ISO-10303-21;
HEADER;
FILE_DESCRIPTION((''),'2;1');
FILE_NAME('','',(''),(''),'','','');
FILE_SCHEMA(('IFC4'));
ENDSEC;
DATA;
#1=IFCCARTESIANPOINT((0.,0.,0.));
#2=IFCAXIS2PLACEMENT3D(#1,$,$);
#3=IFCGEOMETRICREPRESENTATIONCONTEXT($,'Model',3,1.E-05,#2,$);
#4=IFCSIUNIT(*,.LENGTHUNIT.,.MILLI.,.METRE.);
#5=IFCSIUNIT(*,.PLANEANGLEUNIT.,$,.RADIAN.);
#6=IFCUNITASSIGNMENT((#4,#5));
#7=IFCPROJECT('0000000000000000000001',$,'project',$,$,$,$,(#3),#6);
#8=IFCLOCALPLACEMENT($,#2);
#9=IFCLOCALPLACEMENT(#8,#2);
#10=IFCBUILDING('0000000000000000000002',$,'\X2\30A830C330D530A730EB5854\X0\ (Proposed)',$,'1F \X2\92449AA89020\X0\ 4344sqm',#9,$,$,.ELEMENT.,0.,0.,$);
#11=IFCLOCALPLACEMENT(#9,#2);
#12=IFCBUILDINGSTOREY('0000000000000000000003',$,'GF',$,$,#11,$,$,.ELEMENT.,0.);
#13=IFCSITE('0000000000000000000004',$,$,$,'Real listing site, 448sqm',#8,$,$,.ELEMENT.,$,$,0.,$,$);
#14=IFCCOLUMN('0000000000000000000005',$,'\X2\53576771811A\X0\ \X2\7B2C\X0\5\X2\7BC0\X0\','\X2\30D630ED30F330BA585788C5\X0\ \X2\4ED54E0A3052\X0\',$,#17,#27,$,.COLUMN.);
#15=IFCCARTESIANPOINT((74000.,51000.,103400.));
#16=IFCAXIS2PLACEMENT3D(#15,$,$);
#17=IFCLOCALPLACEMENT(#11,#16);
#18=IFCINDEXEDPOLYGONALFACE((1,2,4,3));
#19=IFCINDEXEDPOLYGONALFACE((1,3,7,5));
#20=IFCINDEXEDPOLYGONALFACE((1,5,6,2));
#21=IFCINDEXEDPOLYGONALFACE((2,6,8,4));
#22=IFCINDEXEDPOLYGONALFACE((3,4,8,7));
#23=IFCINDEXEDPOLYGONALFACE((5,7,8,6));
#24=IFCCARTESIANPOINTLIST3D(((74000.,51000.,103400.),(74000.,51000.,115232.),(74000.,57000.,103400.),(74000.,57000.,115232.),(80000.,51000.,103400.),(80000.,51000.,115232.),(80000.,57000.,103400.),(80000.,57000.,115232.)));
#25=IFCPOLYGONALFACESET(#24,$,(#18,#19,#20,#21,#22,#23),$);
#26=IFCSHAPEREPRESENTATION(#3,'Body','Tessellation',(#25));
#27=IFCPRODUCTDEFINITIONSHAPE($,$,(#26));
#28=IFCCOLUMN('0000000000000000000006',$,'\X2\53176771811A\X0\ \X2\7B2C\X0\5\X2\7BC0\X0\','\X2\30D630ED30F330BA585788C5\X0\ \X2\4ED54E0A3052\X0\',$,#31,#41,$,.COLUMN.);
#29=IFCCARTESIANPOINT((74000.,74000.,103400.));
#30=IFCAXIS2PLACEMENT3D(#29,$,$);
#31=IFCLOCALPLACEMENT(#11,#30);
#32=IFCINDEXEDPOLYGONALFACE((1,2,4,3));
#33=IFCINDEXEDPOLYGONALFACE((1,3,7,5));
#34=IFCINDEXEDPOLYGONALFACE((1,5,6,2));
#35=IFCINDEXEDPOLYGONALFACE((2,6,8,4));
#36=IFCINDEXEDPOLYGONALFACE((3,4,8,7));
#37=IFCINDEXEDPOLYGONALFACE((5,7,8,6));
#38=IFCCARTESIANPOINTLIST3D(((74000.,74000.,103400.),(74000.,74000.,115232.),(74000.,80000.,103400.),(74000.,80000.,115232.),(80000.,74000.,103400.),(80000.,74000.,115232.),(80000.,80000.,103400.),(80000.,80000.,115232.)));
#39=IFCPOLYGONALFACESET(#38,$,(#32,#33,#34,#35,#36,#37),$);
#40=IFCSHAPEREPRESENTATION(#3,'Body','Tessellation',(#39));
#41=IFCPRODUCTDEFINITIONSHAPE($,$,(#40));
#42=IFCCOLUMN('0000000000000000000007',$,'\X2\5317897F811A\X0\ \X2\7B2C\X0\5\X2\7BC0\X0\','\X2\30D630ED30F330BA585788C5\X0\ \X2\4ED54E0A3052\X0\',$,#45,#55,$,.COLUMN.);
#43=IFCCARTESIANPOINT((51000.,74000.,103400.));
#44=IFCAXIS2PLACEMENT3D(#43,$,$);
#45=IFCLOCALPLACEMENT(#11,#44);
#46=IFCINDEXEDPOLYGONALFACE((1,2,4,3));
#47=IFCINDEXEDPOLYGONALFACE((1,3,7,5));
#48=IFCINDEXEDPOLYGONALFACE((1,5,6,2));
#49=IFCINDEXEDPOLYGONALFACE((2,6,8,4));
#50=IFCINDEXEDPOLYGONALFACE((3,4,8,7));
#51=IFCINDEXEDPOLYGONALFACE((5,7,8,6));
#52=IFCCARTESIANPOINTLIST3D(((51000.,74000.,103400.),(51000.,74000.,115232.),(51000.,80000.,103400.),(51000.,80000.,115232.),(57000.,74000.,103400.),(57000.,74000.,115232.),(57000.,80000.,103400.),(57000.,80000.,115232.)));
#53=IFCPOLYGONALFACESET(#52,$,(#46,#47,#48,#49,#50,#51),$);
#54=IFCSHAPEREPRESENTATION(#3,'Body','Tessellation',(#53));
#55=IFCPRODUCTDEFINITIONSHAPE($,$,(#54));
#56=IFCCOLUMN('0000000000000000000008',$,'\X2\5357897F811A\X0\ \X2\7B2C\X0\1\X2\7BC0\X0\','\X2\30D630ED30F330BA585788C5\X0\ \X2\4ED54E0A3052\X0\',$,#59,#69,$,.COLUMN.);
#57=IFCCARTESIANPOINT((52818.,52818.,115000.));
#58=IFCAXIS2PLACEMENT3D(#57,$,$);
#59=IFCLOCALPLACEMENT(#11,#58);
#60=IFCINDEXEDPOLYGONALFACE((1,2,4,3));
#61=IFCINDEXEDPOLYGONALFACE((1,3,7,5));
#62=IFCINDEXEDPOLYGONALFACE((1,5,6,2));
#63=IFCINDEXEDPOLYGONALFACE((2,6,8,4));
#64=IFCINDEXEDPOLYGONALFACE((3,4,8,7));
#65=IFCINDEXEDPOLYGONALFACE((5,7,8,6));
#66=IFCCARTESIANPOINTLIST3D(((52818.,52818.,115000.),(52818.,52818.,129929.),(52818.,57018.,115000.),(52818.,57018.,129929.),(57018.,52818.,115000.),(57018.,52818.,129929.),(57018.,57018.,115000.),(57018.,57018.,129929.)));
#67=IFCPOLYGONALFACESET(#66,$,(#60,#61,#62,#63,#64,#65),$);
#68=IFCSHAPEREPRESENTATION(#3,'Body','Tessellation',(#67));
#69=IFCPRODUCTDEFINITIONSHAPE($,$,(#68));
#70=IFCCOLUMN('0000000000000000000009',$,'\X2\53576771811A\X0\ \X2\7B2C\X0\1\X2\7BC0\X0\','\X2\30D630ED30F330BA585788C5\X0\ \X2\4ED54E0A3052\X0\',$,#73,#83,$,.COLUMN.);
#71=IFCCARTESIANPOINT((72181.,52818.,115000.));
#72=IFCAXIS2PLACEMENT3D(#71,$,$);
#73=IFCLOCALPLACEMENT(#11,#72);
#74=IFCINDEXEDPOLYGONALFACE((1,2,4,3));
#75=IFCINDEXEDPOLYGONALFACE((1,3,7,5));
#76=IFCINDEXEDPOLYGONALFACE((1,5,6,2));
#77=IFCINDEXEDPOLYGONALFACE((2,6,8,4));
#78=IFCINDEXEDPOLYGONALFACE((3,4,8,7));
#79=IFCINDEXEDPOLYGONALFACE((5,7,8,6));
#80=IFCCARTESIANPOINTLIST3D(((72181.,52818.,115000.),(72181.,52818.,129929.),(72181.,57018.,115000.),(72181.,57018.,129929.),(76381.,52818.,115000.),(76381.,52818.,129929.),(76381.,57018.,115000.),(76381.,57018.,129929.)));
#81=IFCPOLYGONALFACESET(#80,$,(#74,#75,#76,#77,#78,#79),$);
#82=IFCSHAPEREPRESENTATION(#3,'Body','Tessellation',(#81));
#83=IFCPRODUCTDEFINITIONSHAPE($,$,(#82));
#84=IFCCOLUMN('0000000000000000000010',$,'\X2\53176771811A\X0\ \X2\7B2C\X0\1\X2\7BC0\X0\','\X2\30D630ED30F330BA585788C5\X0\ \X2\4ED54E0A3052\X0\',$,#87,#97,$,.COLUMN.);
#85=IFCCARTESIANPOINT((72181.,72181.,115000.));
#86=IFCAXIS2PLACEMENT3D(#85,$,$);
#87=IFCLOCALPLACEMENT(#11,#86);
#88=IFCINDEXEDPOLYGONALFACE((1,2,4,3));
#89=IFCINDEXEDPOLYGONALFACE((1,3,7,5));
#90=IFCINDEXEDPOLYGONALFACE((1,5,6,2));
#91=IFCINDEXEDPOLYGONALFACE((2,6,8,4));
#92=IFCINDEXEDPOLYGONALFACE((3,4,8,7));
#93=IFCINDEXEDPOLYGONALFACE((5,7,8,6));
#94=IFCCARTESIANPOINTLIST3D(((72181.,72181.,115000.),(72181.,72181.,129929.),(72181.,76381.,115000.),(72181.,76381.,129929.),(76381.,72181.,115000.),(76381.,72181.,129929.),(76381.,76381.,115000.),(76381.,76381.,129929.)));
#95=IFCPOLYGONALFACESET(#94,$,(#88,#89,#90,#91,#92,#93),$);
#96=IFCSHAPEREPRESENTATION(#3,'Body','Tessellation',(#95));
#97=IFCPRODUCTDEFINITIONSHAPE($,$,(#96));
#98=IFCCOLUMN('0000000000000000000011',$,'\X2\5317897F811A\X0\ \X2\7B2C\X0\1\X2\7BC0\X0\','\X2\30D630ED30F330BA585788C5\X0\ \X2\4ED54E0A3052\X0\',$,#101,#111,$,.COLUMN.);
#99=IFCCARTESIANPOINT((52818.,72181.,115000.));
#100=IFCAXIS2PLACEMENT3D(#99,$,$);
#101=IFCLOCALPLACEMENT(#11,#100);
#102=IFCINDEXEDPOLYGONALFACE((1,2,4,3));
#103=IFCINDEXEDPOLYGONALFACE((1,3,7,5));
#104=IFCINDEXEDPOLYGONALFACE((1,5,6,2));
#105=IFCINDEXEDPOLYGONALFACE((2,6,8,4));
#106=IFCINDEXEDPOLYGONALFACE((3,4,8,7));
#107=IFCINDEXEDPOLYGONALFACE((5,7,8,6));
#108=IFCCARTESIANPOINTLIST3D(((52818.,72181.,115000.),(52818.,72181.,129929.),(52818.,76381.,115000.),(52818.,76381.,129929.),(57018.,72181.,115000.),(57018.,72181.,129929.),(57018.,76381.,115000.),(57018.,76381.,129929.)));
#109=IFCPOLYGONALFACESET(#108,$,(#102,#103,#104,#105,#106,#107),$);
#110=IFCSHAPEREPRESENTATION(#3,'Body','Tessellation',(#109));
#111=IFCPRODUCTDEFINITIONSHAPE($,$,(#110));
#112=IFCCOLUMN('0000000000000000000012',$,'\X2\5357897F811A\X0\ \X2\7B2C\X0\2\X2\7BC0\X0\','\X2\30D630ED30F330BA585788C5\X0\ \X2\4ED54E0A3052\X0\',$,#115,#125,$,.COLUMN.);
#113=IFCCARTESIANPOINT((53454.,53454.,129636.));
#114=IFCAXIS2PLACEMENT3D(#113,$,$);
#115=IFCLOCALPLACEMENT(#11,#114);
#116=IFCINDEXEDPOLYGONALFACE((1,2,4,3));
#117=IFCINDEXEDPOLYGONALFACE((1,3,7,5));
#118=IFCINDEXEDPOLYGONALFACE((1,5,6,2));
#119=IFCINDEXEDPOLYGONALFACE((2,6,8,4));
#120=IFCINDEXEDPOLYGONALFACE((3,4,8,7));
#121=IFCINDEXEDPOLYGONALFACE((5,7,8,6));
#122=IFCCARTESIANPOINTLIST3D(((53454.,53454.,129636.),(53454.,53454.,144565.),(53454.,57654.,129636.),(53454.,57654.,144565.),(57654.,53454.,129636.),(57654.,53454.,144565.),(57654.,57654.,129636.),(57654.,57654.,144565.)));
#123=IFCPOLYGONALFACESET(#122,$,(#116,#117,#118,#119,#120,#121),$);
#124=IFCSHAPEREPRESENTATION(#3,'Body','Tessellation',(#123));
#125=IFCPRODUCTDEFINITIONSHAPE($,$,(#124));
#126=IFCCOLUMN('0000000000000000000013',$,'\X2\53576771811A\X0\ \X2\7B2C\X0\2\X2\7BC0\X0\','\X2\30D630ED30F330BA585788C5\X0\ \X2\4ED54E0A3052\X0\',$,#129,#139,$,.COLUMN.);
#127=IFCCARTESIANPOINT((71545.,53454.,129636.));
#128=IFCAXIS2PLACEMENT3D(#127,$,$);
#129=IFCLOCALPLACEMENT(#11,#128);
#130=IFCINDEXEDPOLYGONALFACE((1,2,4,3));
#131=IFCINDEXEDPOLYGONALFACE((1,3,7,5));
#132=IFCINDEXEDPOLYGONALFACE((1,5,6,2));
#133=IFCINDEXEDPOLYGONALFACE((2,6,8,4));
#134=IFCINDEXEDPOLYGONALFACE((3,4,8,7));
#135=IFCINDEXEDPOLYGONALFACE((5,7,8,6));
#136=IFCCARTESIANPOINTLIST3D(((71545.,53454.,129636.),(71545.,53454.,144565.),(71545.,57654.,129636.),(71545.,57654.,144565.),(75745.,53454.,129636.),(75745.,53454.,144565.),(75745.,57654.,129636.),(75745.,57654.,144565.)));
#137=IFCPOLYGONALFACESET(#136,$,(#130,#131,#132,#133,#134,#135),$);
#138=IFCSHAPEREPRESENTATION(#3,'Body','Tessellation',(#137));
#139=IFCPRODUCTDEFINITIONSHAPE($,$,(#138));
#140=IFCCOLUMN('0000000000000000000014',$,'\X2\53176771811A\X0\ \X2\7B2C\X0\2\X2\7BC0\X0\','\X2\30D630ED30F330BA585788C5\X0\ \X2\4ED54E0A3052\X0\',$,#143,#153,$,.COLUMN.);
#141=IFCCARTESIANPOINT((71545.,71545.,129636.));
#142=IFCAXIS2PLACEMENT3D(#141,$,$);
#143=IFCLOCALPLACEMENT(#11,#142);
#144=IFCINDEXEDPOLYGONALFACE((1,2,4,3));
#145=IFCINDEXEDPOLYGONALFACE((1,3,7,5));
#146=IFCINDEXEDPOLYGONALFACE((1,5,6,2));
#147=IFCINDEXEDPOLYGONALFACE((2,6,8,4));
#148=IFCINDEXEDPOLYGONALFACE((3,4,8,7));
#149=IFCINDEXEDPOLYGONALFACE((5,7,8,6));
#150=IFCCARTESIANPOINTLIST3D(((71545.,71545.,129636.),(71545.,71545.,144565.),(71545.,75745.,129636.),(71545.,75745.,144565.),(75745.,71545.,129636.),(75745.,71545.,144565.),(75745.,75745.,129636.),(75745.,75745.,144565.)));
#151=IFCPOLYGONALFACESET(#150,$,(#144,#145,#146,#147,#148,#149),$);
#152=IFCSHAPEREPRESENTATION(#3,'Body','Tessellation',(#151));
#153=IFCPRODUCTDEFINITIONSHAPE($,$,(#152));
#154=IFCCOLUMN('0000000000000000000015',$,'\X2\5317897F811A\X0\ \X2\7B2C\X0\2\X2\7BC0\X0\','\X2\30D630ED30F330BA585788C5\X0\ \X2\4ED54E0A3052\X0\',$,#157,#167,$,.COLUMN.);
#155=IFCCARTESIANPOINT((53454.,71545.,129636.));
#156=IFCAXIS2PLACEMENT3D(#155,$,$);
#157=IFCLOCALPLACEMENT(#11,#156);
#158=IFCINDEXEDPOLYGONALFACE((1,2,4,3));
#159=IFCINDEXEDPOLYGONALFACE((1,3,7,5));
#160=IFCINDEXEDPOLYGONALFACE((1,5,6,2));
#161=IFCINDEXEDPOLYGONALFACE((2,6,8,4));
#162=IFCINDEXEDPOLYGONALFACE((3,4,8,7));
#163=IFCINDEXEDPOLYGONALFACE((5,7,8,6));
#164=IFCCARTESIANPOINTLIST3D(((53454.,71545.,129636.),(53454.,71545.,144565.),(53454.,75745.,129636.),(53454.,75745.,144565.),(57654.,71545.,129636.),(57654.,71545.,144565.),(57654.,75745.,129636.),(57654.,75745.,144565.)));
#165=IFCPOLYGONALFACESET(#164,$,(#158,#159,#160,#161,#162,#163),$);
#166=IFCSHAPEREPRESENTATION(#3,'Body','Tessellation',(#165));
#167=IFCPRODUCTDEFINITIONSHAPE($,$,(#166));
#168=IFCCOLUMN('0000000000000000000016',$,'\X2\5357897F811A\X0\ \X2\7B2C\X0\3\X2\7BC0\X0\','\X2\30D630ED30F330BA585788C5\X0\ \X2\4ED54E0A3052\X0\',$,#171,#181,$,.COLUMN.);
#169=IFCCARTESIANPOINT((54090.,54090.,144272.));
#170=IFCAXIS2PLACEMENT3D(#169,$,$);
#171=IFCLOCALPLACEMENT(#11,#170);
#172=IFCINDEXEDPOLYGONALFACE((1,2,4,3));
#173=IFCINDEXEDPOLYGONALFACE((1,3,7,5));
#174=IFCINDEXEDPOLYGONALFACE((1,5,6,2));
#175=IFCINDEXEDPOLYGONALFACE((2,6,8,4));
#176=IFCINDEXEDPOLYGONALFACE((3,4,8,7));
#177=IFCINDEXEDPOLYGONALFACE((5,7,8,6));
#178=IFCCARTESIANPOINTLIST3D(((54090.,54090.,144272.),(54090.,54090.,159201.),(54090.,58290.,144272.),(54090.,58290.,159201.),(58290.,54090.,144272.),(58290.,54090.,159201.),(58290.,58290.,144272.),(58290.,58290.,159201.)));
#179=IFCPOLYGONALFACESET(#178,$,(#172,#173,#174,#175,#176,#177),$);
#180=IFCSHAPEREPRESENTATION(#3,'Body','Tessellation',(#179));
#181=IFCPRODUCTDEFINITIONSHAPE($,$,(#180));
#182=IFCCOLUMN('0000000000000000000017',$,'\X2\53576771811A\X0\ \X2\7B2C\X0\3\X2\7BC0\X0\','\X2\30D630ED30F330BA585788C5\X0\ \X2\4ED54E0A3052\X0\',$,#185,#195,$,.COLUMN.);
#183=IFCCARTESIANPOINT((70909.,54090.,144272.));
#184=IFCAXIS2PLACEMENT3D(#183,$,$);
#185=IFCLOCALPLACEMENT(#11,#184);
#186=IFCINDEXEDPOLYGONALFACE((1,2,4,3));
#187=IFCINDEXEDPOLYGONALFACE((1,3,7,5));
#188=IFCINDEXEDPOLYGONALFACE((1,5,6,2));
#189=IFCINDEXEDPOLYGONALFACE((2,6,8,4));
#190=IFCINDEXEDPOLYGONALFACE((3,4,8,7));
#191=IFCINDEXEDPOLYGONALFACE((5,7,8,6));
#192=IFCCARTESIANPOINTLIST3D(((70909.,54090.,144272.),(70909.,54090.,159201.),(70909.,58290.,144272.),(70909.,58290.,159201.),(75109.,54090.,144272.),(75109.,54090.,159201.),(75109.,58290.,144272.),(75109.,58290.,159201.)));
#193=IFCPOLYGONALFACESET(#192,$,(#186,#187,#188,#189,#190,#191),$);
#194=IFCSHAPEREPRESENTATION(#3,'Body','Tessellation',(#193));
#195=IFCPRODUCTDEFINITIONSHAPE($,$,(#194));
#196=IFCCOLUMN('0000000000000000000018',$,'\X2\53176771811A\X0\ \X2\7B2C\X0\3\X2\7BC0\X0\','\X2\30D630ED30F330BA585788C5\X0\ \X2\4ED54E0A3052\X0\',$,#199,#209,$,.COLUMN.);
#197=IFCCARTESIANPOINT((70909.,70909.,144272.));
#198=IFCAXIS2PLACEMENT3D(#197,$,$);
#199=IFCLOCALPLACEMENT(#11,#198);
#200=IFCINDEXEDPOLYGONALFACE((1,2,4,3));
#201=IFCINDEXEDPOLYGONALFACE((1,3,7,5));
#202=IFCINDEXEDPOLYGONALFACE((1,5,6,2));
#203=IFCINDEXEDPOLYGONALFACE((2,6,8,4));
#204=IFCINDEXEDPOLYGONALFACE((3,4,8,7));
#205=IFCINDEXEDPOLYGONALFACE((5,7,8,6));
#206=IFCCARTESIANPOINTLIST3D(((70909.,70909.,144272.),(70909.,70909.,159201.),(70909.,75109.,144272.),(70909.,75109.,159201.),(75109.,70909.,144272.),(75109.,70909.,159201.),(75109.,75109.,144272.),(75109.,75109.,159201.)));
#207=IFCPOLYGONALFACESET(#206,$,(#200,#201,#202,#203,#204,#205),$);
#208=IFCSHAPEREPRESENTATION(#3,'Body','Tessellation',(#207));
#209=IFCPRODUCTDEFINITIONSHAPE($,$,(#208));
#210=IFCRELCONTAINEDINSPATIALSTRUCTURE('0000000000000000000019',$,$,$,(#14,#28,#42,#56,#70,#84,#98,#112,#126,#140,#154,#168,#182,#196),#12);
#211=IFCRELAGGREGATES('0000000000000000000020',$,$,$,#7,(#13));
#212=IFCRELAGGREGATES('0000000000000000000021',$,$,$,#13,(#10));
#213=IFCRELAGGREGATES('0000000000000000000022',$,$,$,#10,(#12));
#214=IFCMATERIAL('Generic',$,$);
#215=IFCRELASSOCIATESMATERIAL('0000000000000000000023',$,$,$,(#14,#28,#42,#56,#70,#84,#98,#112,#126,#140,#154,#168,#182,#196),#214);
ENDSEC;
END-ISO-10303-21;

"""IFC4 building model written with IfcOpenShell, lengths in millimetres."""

from ifc_helpers import new_model, si_unit, frame, frame_2d, origin, place, context, project, spatial, rectangle, extrude, material, element, save


model = new_model("IFC4")

# Units and contexts
model_context = context("Model", 3, precision=1e-05, world=origin())
ifc_project = project(units=[si_unit("LENGTHUNIT", "METRE", prefix="MILLI"), si_unit("PLANEANGLEUNIT", "RADIAN")], contexts=[model_context])

# Site, building, storey
site_placement = place(None, origin())
site = spatial("IfcSite", under=ifc_project, at=site_placement, ObjectType="Real listing site, 448sqm", CompositionType="ELEMENT", RefElevation=0.0)
building_placement = place(site_placement, origin())
building = spatial("IfcBuilding", under=site, at=building_placement, Name="エッフェル塔 (Proposed)", ObjectType="1F 鉄骨造 4344sqm", CompositionType="ELEMENT", ElevationOfRefHeight=0.0, ElevationOfTerrain=0.0)
storey_placement = place(building_placement, origin())
storey = spatial("IfcBuildingStorey", under=building, at=storey_placement, Name="GF", CompositionType="ELEMENT", Elevation=0.0)

# Columns
ifc_material = material(Name="Generic")
column_1_placement = place(storey_placement, frame((74000.0, 51000.0, 103400.0)))
element("IfcColumn", 1, at=column_1_placement, inside=storey, material=ifc_material, Name="南東脚 第5節", Description="ブロンズ塗装 仕上げ", PredefinedType="COLUMN", context=model_context, shape_type="SweptSolid", body=[
    extrude(rectangle(XDim=6000.0, YDim=6000.0, at=frame_2d((3000.0, 3000.0))), frame((74000.0, 51000.0, 103400.0)), (0.0, 0.0, 1.0), 11832.0),
])
column_2_placement = place(storey_placement, frame((74000.0, 74000.0, 103400.0)))
element("IfcColumn", 2, at=column_2_placement, inside=storey, material=ifc_material, Name="北東脚 第5節", Description="ブロンズ塗装 仕上げ", PredefinedType="COLUMN", context=model_context, shape_type="SweptSolid", body=[
    extrude(rectangle(XDim=6000.0, YDim=6000.0, at=frame_2d((3000.0, 3000.0))), frame((74000.0, 74000.0, 103400.0)), (0.0, 0.0, 1.0), 11832.0),
])
column_3_placement = place(storey_placement, frame((51000.0, 74000.0, 103400.0)))
element("IfcColumn", 3, at=column_3_placement, inside=storey, material=ifc_material, Name="北西脚 第5節", Description="ブロンズ塗装 仕上げ", PredefinedType="COLUMN", context=model_context, shape_type="SweptSolid", body=[
    extrude(rectangle(XDim=6000.0, YDim=6000.0, at=frame_2d((3000.0, 3000.0))), frame((51000.0, 74000.0, 103400.0)), (0.0, 0.0, 1.0), 11832.0),
])
column_4_placement = place(storey_placement, frame((52818.0, 52818.0, 115000.0)))
element("IfcColumn", 4, at=column_4_placement, inside=storey, material=ifc_material, Name="南西脚 第1節", Description="ブロンズ塗装 仕上げ", PredefinedType="COLUMN", context=model_context, shape_type="SweptSolid", body=[
    extrude(rectangle(XDim=4200.0, YDim=4200.0, at=frame_2d((2100.0, 2100.0))), frame((52818.0, 52818.0, 115000.0)), (0.0, 0.0, 1.0), 14929.0),
])
column_5_placement = place(storey_placement, frame((72181.0, 52818.0, 115000.0)))
element("IfcColumn", 5, at=column_5_placement, inside=storey, material=ifc_material, Name="南東脚 第1節", Description="ブロンズ塗装 仕上げ", PredefinedType="COLUMN", context=model_context, shape_type="SweptSolid", body=[
    extrude(rectangle(XDim=4200.0, YDim=4200.0, at=frame_2d((2100.0, 2100.0))), frame((72181.0, 52818.0, 115000.0)), (0.0, 0.0, 1.0), 14929.0),
])
column_6_placement = place(storey_placement, frame((72181.0, 72181.0, 115000.0)))
element("IfcColumn", 6, at=column_6_placement, inside=storey, material=ifc_material, Name="北東脚 第1節", Description="ブロンズ塗装 仕上げ", PredefinedType="COLUMN", context=model_context, shape_type="SweptSolid", body=[
    extrude(rectangle(XDim=4200.0, YDim=4200.0, at=frame_2d((2100.0, 2100.0))), frame((72181.0, 72181.0, 115000.0)), (0.0, 0.0, 1.0), 14929.0),
])
column_7_placement = place(storey_placement, frame((52818.0, 72181.0, 115000.0)))
element("IfcColumn", 7, at=column_7_placement, inside=storey, material=ifc_material, Name="北西脚 第1節", Description="ブロンズ塗装 仕上げ", PredefinedType="COLUMN", context=model_context, shape_type="SweptSolid", body=[
    extrude(rectangle(XDim=4200.0, YDim=4200.0, at=frame_2d((2100.0, 2100.0))), frame((52818.0, 72181.0, 115000.0)), (0.0, 0.0, 1.0), 14929.0),
])
column_8_placement = place(storey_placement, frame((53454.0, 53454.0, 129636.0)))
element("IfcColumn", 8, at=column_8_placement, inside=storey, material=ifc_material, Name="南西脚 第2節", Description="ブロンズ塗装 仕上げ", PredefinedType="COLUMN", context=model_context, shape_type="SweptSolid", body=[
    extrude(rectangle(XDim=4200.0, YDim=4200.0, at=frame_2d((2100.0, 2100.0))), frame((53454.0, 53454.0, 129636.0)), (0.0, 0.0, 1.0), 14929.0),
])
column_9_placement = place(storey_placement, frame((71545.0, 53454.0, 129636.0)))
element("IfcColumn", 9, at=column_9_placement, inside=storey, material=ifc_material, Name="南東脚 第2節", Description="ブロンズ塗装 仕上げ", PredefinedType="COLUMN", context=model_context, shape_type="SweptSolid", body=[
    extrude(rectangle(XDim=4200.0, YDim=4200.0, at=frame_2d((2100.0, 2100.0))), frame((71545.0, 53454.0, 129636.0)), (0.0, 0.0, 1.0), 14929.0),
])
column_10_placement = place(storey_placement, frame((71545.0, 71545.0, 129636.0)))
element("IfcColumn", 10, at=column_10_placement, inside=storey, material=ifc_material, Name="北東脚 第2節", Description="ブロンズ塗装 仕上げ", PredefinedType="COLUMN", context=model_context, shape_type="SweptSolid", body=[
    extrude(rectangle(XDim=4200.0, YDim=4200.0, at=frame_2d((2100.0, 2100.0))), frame((71545.0, 71545.0, 129636.0)), (0.0, 0.0, 1.0), 14929.0),
])
column_11_placement = place(storey_placement, frame((53454.0, 71545.0, 129636.0)))
element("IfcColumn", 11, at=column_11_placement, inside=storey, material=ifc_material, Name="北西脚 第2節", Description="ブロンズ塗装 仕上げ", PredefinedType="COLUMN", context=model_context, shape_type="SweptSolid", body=[
    extrude(rectangle(XDim=4200.0, YDim=4200.0, at=frame_2d((2100.0, 2100.0))), frame((53454.0, 71545.0, 129636.0)), (0.0, 0.0, 1.0), 14929.0),
])
column_12_placement = place(storey_placement, frame((54090.0, 54090.0, 144272.0)))
element("IfcColumn", 12, at=column_12_placement, inside=storey, material=ifc_material, Name="南西脚 第3節", Description="ブロンズ塗装 仕上げ", PredefinedType="COLUMN", context=model_context, shape_type="SweptSolid", body=[
    extrude(rectangle(XDim=4200.0, YDim=4200.0, at=frame_2d((2100.0, 2100.0))), frame((54090.0, 54090.0, 144272.0)), (0.0, 0.0, 1.0), 14929.0),
])
column_13_placement = place(storey_placement, frame((70909.0, 54090.0, 144272.0)))
element("IfcColumn", 13, at=column_13_placement, inside=storey, material=ifc_material, Name="南東脚 第3節", Description="ブロンズ塗装 仕上げ", PredefinedType="COLUMN", context=model_context, shape_type="SweptSolid", body=[
    extrude(rectangle(XDim=4200.0, YDim=4200.0, at=frame_2d((2100.0, 2100.0))), frame((70909.0, 54090.0, 144272.0)), (0.0, 0.0, 1.0), 14929.0),
])
column_14_placement = place(storey_placement, frame((70909.0, 70909.0, 144272.0)))
element("IfcColumn", 14, at=column_14_placement, inside=storey, material=ifc_material, Name="北東脚 第3節", Description="ブロンズ塗装 仕上げ", PredefinedType="COLUMN", context=model_context, shape_type="SweptSolid", body=[
    extrude(rectangle(XDim=4200.0, YDim=4200.0, at=frame_2d((2100.0, 2100.0))), frame((70909.0, 70909.0, 144272.0)), (0.0, 0.0, 1.0), 14929.0),
])

save(model, "model.ifc")
